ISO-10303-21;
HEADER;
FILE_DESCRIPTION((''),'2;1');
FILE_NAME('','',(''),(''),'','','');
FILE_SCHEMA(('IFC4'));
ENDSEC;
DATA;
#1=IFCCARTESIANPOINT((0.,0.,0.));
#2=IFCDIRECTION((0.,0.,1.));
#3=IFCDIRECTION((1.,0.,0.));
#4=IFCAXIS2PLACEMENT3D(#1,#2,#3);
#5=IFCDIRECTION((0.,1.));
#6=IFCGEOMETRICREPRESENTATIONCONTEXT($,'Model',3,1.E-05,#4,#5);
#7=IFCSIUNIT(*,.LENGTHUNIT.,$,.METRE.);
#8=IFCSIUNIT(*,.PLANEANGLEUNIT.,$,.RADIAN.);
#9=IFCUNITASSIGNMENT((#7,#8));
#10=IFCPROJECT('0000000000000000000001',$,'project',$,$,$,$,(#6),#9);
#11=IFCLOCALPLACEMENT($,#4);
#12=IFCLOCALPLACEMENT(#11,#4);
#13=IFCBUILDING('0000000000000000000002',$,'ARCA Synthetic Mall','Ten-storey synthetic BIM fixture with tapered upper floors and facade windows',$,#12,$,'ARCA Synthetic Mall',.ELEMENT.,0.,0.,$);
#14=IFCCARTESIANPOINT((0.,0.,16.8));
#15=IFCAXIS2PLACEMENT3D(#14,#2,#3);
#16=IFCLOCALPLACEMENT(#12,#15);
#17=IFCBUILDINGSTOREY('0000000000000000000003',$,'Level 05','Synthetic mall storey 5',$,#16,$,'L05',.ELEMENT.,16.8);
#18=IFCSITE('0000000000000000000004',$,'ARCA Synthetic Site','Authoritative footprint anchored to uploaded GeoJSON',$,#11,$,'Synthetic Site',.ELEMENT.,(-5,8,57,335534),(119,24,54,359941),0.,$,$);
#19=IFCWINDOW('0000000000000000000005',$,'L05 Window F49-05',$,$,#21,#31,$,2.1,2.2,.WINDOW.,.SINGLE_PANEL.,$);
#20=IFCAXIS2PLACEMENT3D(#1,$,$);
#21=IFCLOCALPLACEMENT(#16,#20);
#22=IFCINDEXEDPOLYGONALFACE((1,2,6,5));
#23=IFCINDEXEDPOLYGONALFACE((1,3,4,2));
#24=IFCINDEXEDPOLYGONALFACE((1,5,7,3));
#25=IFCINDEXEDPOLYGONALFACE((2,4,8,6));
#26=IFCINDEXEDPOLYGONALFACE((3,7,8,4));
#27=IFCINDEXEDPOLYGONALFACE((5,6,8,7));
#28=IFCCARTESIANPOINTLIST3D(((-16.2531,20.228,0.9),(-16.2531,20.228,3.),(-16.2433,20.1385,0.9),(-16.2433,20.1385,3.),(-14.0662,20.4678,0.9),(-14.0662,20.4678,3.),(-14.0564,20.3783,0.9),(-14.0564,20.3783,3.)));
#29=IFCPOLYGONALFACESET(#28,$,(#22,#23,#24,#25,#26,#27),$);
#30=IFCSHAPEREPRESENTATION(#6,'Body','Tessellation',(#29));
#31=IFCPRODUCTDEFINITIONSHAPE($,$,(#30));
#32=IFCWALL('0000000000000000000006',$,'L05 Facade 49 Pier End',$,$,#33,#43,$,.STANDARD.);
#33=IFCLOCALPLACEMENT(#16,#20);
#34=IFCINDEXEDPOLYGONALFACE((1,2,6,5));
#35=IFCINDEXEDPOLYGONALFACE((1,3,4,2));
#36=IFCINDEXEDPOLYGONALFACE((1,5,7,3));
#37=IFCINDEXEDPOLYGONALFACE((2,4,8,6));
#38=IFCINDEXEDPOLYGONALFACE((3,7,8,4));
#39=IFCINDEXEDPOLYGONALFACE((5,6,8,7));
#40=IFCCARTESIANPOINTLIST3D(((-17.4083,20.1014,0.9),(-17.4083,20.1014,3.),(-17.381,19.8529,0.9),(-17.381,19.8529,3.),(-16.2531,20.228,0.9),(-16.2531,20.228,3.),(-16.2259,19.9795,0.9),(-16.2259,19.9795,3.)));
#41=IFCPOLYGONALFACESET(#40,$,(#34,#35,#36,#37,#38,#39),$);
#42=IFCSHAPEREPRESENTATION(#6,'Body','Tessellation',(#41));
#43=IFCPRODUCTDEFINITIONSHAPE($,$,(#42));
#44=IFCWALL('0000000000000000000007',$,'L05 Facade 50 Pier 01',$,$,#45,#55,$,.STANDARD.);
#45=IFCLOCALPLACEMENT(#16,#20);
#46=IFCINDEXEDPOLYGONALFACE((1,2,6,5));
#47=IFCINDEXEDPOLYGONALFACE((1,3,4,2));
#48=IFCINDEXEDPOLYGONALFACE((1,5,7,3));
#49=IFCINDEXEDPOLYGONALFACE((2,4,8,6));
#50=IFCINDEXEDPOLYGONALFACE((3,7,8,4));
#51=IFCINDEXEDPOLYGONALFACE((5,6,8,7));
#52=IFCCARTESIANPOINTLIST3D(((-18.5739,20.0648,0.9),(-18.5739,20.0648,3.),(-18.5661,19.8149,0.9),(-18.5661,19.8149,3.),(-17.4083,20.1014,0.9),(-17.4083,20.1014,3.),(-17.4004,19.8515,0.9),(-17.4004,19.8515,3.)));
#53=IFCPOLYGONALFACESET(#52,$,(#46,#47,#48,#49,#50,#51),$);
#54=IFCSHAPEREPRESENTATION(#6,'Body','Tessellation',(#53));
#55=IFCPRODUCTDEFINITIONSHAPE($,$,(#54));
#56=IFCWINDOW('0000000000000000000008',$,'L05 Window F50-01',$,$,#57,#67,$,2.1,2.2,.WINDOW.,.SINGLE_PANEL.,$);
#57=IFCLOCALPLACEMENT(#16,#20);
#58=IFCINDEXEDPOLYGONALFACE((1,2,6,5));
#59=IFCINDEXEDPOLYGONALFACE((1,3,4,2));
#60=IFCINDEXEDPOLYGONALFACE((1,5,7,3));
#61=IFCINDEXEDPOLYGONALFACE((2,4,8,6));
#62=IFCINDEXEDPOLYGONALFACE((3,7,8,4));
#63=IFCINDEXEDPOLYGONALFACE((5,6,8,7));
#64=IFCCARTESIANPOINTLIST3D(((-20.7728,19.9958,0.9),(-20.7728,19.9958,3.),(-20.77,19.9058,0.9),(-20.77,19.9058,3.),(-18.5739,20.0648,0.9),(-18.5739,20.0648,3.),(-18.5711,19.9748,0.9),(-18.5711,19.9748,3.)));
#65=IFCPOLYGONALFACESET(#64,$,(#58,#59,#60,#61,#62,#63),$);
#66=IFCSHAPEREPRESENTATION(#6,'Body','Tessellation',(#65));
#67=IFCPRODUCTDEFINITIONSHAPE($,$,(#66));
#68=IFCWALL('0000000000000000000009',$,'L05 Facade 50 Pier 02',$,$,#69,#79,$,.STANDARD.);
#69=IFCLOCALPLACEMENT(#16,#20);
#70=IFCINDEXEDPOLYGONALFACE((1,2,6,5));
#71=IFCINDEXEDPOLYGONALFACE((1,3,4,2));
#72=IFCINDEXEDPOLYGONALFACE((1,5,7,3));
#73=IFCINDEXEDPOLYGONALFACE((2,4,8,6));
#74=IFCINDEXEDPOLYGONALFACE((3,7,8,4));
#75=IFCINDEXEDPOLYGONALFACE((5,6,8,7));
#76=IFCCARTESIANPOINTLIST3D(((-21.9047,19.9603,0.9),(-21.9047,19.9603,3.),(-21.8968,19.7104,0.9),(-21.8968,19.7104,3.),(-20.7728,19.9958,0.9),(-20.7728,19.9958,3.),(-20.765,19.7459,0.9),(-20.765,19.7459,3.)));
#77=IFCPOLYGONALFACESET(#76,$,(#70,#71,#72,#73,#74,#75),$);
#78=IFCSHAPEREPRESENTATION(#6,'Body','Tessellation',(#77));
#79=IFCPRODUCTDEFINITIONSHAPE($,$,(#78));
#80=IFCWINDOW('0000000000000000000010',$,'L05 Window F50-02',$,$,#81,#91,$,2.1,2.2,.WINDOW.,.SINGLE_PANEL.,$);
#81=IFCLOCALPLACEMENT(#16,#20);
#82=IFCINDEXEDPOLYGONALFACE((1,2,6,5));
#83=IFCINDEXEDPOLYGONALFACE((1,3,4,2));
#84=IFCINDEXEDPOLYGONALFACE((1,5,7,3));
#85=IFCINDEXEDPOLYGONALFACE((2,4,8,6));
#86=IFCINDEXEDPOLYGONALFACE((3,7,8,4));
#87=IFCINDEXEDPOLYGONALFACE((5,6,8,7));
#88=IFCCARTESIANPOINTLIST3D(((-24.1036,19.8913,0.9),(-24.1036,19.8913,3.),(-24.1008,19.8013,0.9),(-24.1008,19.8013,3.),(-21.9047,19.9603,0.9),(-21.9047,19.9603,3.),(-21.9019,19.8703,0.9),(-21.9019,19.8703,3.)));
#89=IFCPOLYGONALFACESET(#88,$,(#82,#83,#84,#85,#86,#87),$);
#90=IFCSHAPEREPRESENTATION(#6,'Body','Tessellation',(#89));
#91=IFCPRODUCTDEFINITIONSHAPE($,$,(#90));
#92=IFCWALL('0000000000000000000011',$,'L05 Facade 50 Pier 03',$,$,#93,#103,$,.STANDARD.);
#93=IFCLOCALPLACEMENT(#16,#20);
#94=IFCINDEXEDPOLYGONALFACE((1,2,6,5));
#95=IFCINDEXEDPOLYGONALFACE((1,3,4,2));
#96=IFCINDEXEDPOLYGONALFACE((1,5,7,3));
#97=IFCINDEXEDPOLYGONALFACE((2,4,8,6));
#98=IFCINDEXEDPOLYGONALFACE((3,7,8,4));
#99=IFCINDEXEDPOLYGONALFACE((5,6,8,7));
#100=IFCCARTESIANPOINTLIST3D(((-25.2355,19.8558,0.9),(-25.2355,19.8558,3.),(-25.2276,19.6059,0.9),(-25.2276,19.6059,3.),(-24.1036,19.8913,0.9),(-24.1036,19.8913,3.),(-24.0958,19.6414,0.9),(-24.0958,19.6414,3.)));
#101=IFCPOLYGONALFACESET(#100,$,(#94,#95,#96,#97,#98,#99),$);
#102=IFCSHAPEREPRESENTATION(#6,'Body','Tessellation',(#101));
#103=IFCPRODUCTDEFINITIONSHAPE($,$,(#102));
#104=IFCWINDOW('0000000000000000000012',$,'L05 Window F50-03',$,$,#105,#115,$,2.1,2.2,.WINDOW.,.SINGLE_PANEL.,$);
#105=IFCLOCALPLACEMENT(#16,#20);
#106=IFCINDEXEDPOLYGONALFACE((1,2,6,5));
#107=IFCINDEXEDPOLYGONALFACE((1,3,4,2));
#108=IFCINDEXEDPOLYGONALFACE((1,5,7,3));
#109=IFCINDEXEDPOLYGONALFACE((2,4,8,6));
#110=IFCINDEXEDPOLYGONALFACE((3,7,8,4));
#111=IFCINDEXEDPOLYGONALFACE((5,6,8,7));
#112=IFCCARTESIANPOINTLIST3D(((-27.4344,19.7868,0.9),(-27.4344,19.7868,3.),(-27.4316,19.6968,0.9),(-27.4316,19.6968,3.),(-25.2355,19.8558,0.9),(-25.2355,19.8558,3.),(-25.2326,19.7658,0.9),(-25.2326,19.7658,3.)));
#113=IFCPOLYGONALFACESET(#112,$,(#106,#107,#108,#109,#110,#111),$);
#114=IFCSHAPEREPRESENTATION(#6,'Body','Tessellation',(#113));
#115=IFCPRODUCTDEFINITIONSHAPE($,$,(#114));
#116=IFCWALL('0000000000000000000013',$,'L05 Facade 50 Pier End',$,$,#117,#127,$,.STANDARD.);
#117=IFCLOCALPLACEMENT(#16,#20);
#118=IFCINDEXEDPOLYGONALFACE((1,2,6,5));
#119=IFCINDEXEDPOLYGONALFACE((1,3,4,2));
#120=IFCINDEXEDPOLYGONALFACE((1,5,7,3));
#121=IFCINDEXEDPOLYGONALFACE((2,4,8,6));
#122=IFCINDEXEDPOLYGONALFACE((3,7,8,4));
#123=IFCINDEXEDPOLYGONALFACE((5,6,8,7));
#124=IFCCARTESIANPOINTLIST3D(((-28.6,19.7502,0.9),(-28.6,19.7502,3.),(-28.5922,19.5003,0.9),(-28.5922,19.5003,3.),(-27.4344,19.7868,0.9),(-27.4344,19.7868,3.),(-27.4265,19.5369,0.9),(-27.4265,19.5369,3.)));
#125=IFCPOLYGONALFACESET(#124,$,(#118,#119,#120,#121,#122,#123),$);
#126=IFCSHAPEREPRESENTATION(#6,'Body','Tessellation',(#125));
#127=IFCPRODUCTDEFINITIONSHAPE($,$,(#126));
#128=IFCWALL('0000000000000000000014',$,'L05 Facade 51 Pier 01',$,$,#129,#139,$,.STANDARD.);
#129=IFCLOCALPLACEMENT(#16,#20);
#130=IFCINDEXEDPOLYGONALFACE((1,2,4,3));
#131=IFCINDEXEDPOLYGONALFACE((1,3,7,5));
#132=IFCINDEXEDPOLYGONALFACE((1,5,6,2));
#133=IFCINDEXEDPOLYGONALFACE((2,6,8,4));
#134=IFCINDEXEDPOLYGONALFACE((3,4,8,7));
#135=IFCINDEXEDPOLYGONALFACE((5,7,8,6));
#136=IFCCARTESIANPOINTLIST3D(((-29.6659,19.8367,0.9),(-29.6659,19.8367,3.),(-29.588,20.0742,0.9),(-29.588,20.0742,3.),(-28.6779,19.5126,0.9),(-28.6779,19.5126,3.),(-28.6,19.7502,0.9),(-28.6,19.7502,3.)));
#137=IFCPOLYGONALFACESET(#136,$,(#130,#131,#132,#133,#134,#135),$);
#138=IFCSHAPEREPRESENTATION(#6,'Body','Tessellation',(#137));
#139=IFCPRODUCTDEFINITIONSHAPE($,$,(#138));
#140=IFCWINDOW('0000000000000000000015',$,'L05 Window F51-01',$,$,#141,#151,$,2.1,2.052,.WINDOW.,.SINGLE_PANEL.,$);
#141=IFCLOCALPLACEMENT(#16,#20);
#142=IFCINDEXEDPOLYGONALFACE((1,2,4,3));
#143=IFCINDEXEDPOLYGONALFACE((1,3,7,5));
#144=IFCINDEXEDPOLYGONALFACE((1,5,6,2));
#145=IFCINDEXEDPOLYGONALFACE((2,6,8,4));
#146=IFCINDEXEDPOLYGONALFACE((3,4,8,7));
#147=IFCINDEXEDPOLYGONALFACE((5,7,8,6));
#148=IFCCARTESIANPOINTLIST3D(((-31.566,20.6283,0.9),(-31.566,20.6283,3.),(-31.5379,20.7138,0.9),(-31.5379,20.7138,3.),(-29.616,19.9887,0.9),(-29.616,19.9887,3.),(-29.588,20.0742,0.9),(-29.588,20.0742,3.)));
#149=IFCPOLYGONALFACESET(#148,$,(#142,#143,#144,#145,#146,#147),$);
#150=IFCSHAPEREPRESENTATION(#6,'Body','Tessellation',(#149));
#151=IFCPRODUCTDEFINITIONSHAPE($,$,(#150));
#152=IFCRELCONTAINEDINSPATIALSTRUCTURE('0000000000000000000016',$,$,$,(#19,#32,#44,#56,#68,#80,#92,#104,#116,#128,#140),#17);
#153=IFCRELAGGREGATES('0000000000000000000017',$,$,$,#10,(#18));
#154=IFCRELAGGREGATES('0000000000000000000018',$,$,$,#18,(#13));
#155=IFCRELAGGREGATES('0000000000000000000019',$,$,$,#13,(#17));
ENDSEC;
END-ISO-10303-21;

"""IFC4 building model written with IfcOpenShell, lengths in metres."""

from ifc_helpers import new_model, si_unit, direction, frame, origin_with_axes, place, context, project, spatial, polyline, outline, extrude, element, save


model = new_model("IFC4")

# Units and contexts
model_context = context("Model", 3, precision=1e-05, world=origin_with_axes(), true_north=direction((0.0, 1.0)))
ifc_project = project(units=[si_unit("LENGTHUNIT", "METRE"), si_unit("PLANEANGLEUNIT", "RADIAN")], contexts=[model_context])

# Site, building, storey
site_placement = place(None, origin_with_axes())
site = spatial("IfcSite", under=ifc_project, at=site_placement, Name="ARCA Synthetic Site", Description="Authoritative footprint anchored to uploaded GeoJSON", LongName="Synthetic Site", CompositionType="ELEMENT", RefLatitude=(-5, 8, 57, 335534), RefLongitude=(119, 24, 54, 359941), RefElevation=0.0)
building_placement = place(site_placement, origin_with_axes())
building = spatial("IfcBuilding", under=site, at=building_placement, Name="ARCA Synthetic Mall", Description="Ten-storey synthetic BIM fixture with tapered upper floors and facade windows", LongName="ARCA Synthetic Mall", CompositionType="ELEMENT", ElevationOfRefHeight=0.0, ElevationOfTerrain=0.0)
storey_placement = place(building_placement, frame((0.0, 0.0, 16.8), z_axis=(0.0, 0.0, 1.0), x_axis=(1.0, 0.0, 0.0)))
storey = spatial("IfcBuildingStorey", under=building, at=storey_placement, Name="Level 05", Description="Synthetic mall storey 5", LongName="L05", CompositionType="ELEMENT", Elevation=16.8)

# Window
window_1_placement = place(storey_placement, frame((0.0, 0.0, 0.9), z_axis=(0.0, 0.0, 1.0), x_axis=(1.0, 0.0, 0.0)))
element("IfcWindow", 1, at=window_1_placement, inside=storey, Name="L05 Window F49-05", OverallHeight=2.1, OverallWidth=2.2, PartitioningType="SINGLE_PANEL", PredefinedType="WINDOW", context=model_context, shape_type="SweptSolid", body=[
    extrude(outline(polyline([(-14.0662, 20.4678), (-16.2531, 20.228), (-16.2433, 20.1385), (-14.0564, 20.3783), (-14.0662, 20.4678)])), origin_with_axes(), (0.0, 0.0, 1.0), 2.1),
])

# Walls
wall_1_placement = place(storey_placement, frame((0.0, 0.0, 0.9), z_axis=(0.0, 0.0, 1.0), x_axis=(1.0, 0.0, 0.0)))
element("IfcWall", 2, at=wall_1_placement, inside=storey, Name="L05 Facade 49 Pier End", PredefinedType="STANDARD", context=model_context, shape_type="SweptSolid", body=[
    extrude(outline(polyline([(-16.2531, 20.228), (-17.4083, 20.1014), (-17.381, 19.8529), (-16.2259, 19.9795), (-16.2531, 20.228)])), origin_with_axes(), (0.0, 0.0, 1.0), 2.1),
])
wall_2_placement = place(storey_placement, frame((0.0, 0.0, 0.9), z_axis=(0.0, 0.0, 1.0), x_axis=(1.0, 0.0, 0.0)))
element("IfcWall", 3, at=wall_2_placement, inside=storey, Name="L05 Facade 50 Pier 01", PredefinedType="STANDARD", context=model_context, shape_type="SweptSolid", body=[
    extrude(outline(polyline([(-17.4083, 20.1014), (-18.5739, 20.0648), (-18.5661, 19.8149), (-17.4004, 19.8515), (-17.4083, 20.1014)])), origin_with_axes(), (0.0, 0.0, 1.0), 2.1),
])

# Window
window_2_placement = place(storey_placement, frame((0.0, 0.0, 0.9), z_axis=(0.0, 0.0, 1.0), x_axis=(1.0, 0.0, 0.0)))
element("IfcWindow", 4, at=window_2_placement, inside=storey, Name="L05 Window F50-01", OverallHeight=2.1, OverallWidth=2.2, PartitioningType="SINGLE_PANEL", PredefinedType="WINDOW", context=model_context, shape_type="SweptSolid", body=[
    extrude(outline(polyline([(-18.5739, 20.0648), (-20.7728, 19.9958), (-20.77, 19.9058), (-18.5711, 19.9748), (-18.5739, 20.0648)])), origin_with_axes(), (0.0, 0.0, 1.0), 2.1),
])

# Wall
wall_3_placement = place(storey_placement, frame((0.0, 0.0, 0.9), z_axis=(0.0, 0.0, 1.0), x_axis=(1.0, 0.0, 0.0)))
element("IfcWall", 5, at=wall_3_placement, inside=storey, Name="L05 Facade 50 Pier 02", PredefinedType="STANDARD", context=model_context, shape_type="SweptSolid", body=[
    extrude(outline(polyline([(-20.7728, 19.9958), (-21.9047, 19.9603), (-21.8968, 19.7104), (-20.765, 19.7459), (-20.7728, 19.9958)])), origin_with_axes(), (0.0, 0.0, 1.0), 2.1),
])

# Window
window_3_placement = place(storey_placement, frame((0.0, 0.0, 0.9), z_axis=(0.0, 0.0, 1.0), x_axis=(1.0, 0.0, 0.0)))
element("IfcWindow", 6, at=window_3_placement, inside=storey, Name="L05 Window F50-02", OverallHeight=2.1, OverallWidth=2.2, PartitioningType="SINGLE_PANEL", PredefinedType="WINDOW", context=model_context, shape_type="SweptSolid", body=[
    extrude(outline(polyline([(-21.9047, 19.9603), (-24.1036, 19.8913), (-24.1008, 19.8013), (-21.9019, 19.8703), (-21.9047, 19.9603)])), origin_with_axes(), (0.0, 0.0, 1.0), 2.1),
])

# Wall
wall_4_placement = place(storey_placement, frame((0.0, 0.0, 0.9), z_axis=(0.0, 0.0, 1.0), x_axis=(1.0, 0.0, 0.0)))
element("IfcWall", 7, at=wall_4_placement, inside=storey, Name="L05 Facade 50 Pier 03", PredefinedType="STANDARD", context=model_context, shape_type="SweptSolid", body=[
    extrude(outline(polyline([(-24.1036, 19.8913), (-25.2355, 19.8558), (-25.2276, 19.6059), (-24.0958, 19.6414), (-24.1036, 19.8913)])), origin_with_axes(), (0.0, 0.0, 1.0), 2.1),
])

# Window
window_4_placement = place(storey_placement, frame((0.0, 0.0, 0.9), z_axis=(0.0, 0.0, 1.0), x_axis=(1.0, 0.0, 0.0)))
element("IfcWindow", 8, at=window_4_placement, inside=storey, Name="L05 Window F50-03", OverallHeight=2.1, OverallWidth=2.2, PartitioningType="SINGLE_PANEL", PredefinedType="WINDOW", context=model_context, shape_type="SweptSolid", body=[
    extrude(outline(polyline([(-25.2355, 19.8558), (-27.4344, 19.7868), (-27.4316, 19.6968), (-25.2326, 19.7658), (-25.2355, 19.8558)])), origin_with_axes(), (0.0, 0.0, 1.0), 2.1),
])

# Walls
wall_5_placement = place(storey_placement, frame((0.0, 0.0, 0.9), z_axis=(0.0, 0.0, 1.0), x_axis=(1.0, 0.0, 0.0)))
element("IfcWall", 9, at=wall_5_placement, inside=storey, Name="L05 Facade 50 Pier End", PredefinedType="STANDARD", context=model_context, shape_type="SweptSolid", body=[
    extrude(outline(polyline([(-27.4344, 19.7868), (-28.6, 19.7502), (-28.5922, 19.5003), (-27.4265, 19.5369), (-27.4344, 19.7868)])), origin_with_axes(), (0.0, 0.0, 1.0), 2.1),
])
wall_6_placement = place(storey_placement, frame((0.0, 0.0, 0.9), z_axis=(0.0, 0.0, 1.0), x_axis=(1.0, 0.0, 0.0)))
element("IfcWall", 10, at=wall_6_placement, inside=storey, Name="L05 Facade 51 Pier 01", PredefinedType="STANDARD", context=model_context, shape_type="SweptSolid", body=[
    extrude(outline(polyline([(-28.6, 19.7502), (-29.588, 20.0742), (-29.6659, 19.8367), (-28.6779, 19.5126), (-28.6, 19.7502)])), origin_with_axes(), (0.0, 0.0, 1.0), 2.1),
])

# Window
window_5_placement = place(storey_placement, frame((0.0, 0.0, 0.9), z_axis=(0.0, 0.0, 1.0), x_axis=(1.0, 0.0, 0.0)))
element("IfcWindow", 11, at=window_5_placement, inside=storey, Name="L05 Window F51-01", OverallHeight=2.1, OverallWidth=2.052, PartitioningType="SINGLE_PANEL", PredefinedType="WINDOW", context=model_context, shape_type="SweptSolid", body=[
    extrude(outline(polyline([(-29.588, 20.0742), (-31.5379, 20.7138), (-31.566, 20.6283), (-29.616, 19.9887), (-29.588, 20.0742)])), origin_with_axes(), (0.0, 0.0, 1.0), 2.1),
])

save(model, "model.ifc")
